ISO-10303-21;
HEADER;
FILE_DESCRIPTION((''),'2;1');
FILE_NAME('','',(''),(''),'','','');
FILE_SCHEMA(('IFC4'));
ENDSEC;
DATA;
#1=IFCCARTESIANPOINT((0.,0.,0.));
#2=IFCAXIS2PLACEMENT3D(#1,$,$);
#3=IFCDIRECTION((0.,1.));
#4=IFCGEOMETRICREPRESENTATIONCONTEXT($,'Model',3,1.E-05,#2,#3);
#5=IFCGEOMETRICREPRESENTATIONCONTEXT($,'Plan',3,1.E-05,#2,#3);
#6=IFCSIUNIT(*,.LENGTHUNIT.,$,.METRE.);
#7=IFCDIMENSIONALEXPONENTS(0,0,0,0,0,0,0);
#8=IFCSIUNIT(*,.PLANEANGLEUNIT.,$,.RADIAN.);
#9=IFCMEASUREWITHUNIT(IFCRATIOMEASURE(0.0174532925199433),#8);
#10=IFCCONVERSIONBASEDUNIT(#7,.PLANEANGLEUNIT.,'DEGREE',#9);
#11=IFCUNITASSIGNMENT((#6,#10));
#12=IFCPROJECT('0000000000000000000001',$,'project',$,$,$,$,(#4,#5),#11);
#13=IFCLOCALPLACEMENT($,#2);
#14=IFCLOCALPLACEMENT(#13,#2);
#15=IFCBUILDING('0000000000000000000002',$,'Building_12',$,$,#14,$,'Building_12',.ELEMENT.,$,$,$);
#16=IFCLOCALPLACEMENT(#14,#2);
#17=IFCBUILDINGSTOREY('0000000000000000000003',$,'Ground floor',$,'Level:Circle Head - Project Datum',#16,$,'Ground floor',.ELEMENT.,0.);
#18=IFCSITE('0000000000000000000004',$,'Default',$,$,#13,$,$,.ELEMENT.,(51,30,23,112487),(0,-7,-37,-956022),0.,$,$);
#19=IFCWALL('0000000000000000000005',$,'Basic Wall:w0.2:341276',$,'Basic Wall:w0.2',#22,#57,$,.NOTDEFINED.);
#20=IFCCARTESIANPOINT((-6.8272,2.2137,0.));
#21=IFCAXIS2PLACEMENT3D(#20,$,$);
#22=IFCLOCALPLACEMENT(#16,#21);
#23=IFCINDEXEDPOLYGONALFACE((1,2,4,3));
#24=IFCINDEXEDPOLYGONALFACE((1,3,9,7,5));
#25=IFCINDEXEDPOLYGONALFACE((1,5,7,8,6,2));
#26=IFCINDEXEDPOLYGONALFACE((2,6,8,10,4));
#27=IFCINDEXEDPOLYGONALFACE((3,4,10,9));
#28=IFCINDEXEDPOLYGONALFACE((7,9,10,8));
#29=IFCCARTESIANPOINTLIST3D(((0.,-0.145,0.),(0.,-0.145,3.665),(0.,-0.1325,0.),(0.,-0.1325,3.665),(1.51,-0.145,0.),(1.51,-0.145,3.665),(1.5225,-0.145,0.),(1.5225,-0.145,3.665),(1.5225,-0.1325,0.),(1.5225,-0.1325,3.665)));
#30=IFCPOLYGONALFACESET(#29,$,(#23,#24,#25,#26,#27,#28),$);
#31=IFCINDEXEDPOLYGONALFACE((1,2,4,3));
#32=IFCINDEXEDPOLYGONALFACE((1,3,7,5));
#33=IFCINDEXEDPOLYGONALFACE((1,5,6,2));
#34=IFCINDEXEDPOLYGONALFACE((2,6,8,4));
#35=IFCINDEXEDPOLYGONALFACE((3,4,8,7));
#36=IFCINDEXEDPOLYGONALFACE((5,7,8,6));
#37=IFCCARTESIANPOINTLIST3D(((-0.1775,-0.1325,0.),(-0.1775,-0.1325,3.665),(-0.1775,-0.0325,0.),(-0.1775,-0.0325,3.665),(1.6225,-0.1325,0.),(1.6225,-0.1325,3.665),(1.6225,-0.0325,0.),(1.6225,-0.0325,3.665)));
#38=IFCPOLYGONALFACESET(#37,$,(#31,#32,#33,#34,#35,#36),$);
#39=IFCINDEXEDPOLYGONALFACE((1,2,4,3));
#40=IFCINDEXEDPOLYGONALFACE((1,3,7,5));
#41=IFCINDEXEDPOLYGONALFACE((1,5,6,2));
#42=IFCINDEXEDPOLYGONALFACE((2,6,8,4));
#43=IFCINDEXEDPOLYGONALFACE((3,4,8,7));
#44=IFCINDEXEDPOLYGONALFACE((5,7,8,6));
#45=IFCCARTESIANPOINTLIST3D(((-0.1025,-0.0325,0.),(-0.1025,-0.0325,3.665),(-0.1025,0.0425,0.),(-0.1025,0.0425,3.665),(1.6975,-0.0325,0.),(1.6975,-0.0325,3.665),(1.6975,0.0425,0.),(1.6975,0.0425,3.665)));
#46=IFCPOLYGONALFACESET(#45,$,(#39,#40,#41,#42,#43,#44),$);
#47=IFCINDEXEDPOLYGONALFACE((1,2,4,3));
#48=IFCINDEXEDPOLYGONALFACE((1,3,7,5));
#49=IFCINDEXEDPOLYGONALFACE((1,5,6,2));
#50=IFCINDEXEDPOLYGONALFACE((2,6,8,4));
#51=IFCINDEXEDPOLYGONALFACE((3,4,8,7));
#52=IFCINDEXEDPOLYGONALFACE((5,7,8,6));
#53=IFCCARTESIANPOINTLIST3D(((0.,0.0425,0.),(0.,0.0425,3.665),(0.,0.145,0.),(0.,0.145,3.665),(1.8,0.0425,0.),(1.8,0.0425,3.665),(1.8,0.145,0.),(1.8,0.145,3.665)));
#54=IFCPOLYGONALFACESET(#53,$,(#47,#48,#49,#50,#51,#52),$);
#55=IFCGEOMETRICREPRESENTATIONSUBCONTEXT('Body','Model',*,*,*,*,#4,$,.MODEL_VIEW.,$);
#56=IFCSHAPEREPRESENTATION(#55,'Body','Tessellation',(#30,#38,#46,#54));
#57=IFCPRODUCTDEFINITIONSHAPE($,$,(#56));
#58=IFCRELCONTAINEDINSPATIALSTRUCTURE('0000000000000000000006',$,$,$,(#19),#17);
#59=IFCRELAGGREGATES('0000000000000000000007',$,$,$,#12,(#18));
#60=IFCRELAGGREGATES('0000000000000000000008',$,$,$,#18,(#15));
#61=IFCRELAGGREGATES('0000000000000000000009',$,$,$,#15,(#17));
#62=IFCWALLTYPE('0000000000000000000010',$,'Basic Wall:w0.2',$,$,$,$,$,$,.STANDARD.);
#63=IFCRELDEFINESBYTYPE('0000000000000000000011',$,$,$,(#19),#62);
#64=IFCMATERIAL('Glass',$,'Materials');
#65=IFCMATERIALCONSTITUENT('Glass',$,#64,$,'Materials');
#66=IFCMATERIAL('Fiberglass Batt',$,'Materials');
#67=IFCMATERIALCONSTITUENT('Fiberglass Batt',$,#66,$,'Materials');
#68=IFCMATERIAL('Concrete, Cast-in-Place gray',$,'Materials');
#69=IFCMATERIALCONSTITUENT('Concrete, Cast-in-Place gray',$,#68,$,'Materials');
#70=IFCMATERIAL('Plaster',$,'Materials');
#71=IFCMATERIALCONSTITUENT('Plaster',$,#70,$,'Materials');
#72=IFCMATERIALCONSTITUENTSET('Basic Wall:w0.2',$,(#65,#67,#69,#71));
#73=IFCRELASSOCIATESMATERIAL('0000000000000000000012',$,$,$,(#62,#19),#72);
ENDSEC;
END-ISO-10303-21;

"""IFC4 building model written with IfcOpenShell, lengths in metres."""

from ifc_helpers import new_model, entity, si_unit, converted_unit, direction, frame, origin, place, context, subcontext, project, spatial, indexed_curve, outline, extrude, material, constituent, constituent_set, type_object, element, save


model = new_model("IFC4")

# Units and contexts
model_context = context("Model", 3, precision=1e-05, world=origin(), true_north=direction((0.0, 1.0)))
plan_context = context("Plan", 3, precision=1e-05, world=origin(), true_north=direction((0.0, 1.0)))
body_context = subcontext(model_context, "Body", "Model", "MODEL_VIEW")
ifc_project = project(units=[si_unit("LENGTHUNIT", "METRE"), converted_unit("PLANEANGLEUNIT", "DEGREE", entity("IfcRatioMeasure", 0.0174532925199433), si_unit("PLANEANGLEUNIT", "RADIAN"), dimensions=[0, 0, 0, 0, 0, 0, 0])], contexts=[model_context, plan_context])

# Site, building, storey
site_placement = place(None, origin())
site = spatial("IfcSite", under=ifc_project, at=site_placement, Name="Default", CompositionType="ELEMENT", RefLatitude=(51, 30, 23, 112487), RefLongitude=(0, -7, -37, -956022), RefElevation=0.0)
building_placement = place(site_placement, origin())
building = spatial("IfcBuilding", under=site, at=building_placement, Name="Building_12", LongName="Building_12", CompositionType="ELEMENT")
storey_placement = place(building_placement, origin())
storey = spatial("IfcBuildingStorey", under=building, at=storey_placement, Name="Ground floor", ObjectType="Level:Circle Head - Project Datum", LongName="Ground floor", CompositionType="ELEMENT", Elevation=0.0)

# Shared definitions
ifc_material_1 = material(Name="Concrete, Cast-in-Place gray", Category="Materials")

# Shared definitions
ifc_material_2 = material(Name="Glass", Category="Materials")
ifc_constituent_1 = constituent(ifc_material_2, Name="Glass", Category="Materials")
ifc_material_3 = material(Name="Fiberglass Batt", Category="Materials")
ifc_constituent_2 = constituent(ifc_material_3, Name="Fiberglass Batt", Category="Materials")
ifc_constituent_3 = constituent(ifc_material_1, Name="Concrete, Cast-in-Place gray", Category="Materials")
ifc_material_4 = material(Name="Plaster", Category="Materials")
ifc_constituent_4 = constituent(ifc_material_4, Name="Plaster", Category="Materials")
ifc_constituent_set = constituent_set(constituents=[ifc_constituent_1, ifc_constituent_2, ifc_constituent_3, ifc_constituent_4], Name="Basic Wall:w0.2")
wall_type = type_object("IfcWallType", Name="Basic Wall:w0.2", PredefinedType="STANDARD", material=ifc_constituent_set)

# Wall
wall_1_placement = place(storey_placement, frame((-6.8272, 2.2137, 0.0)))
element("IfcWall", 1, at=wall_1_placement, inside=storey, type_object=wall_type, material=ifc_constituent_set, Name="Basic Wall:w0.2:341276", ObjectType="Basic Wall:w0.2", PredefinedType="NOTDEFINED", context=body_context, shape_type="SweptSolid", body=[
    extrude(outline(indexed_curve([(0.599, -0.005), (0.6115, -0.005), (0.6115, 0.0075), (-0.911, 0.0075), (-0.911, -0.005), (0.599, -0.005)], self_intersect=False)), frame((0.911, -0.14, 0.0)), (0.0, 0.0, 1.0), 3.665),
    extrude(outline(indexed_curve([(-0.9, -0.05), (0.9, -0.05), (0.9, 0.05), (-0.9, 0.05), (-0.9, -0.05)], self_intersect=False)), frame((0.7225, -0.0825, 0.0)), (0.0, 0.0, 1.0), 3.665),
    extrude(outline(indexed_curve([(-0.9, -0.0375), (0.9, -0.0375), (0.9, 0.0375), (-0.9, 0.0375), (-0.9, -0.0375)], self_intersect=False)), frame((0.7975, 0.005, 0.0)), (0.0, 0.0, 1.0), 3.665),
    extrude(outline(indexed_curve([(-0.0513, -0.9), (0.0512, -0.9), (0.0513, 0.9), (-0.0512, 0.9), (-0.0513, -0.9)], self_intersect=False)), frame((0.9, 0.0938, 0.0), z_axis=(0.0, 0.0, 1.0), x_axis=(0.0, -1.0, 0.0)), (0.0, 0.0, 1.0), 3.665),
])

save(model, "model.ifc")
